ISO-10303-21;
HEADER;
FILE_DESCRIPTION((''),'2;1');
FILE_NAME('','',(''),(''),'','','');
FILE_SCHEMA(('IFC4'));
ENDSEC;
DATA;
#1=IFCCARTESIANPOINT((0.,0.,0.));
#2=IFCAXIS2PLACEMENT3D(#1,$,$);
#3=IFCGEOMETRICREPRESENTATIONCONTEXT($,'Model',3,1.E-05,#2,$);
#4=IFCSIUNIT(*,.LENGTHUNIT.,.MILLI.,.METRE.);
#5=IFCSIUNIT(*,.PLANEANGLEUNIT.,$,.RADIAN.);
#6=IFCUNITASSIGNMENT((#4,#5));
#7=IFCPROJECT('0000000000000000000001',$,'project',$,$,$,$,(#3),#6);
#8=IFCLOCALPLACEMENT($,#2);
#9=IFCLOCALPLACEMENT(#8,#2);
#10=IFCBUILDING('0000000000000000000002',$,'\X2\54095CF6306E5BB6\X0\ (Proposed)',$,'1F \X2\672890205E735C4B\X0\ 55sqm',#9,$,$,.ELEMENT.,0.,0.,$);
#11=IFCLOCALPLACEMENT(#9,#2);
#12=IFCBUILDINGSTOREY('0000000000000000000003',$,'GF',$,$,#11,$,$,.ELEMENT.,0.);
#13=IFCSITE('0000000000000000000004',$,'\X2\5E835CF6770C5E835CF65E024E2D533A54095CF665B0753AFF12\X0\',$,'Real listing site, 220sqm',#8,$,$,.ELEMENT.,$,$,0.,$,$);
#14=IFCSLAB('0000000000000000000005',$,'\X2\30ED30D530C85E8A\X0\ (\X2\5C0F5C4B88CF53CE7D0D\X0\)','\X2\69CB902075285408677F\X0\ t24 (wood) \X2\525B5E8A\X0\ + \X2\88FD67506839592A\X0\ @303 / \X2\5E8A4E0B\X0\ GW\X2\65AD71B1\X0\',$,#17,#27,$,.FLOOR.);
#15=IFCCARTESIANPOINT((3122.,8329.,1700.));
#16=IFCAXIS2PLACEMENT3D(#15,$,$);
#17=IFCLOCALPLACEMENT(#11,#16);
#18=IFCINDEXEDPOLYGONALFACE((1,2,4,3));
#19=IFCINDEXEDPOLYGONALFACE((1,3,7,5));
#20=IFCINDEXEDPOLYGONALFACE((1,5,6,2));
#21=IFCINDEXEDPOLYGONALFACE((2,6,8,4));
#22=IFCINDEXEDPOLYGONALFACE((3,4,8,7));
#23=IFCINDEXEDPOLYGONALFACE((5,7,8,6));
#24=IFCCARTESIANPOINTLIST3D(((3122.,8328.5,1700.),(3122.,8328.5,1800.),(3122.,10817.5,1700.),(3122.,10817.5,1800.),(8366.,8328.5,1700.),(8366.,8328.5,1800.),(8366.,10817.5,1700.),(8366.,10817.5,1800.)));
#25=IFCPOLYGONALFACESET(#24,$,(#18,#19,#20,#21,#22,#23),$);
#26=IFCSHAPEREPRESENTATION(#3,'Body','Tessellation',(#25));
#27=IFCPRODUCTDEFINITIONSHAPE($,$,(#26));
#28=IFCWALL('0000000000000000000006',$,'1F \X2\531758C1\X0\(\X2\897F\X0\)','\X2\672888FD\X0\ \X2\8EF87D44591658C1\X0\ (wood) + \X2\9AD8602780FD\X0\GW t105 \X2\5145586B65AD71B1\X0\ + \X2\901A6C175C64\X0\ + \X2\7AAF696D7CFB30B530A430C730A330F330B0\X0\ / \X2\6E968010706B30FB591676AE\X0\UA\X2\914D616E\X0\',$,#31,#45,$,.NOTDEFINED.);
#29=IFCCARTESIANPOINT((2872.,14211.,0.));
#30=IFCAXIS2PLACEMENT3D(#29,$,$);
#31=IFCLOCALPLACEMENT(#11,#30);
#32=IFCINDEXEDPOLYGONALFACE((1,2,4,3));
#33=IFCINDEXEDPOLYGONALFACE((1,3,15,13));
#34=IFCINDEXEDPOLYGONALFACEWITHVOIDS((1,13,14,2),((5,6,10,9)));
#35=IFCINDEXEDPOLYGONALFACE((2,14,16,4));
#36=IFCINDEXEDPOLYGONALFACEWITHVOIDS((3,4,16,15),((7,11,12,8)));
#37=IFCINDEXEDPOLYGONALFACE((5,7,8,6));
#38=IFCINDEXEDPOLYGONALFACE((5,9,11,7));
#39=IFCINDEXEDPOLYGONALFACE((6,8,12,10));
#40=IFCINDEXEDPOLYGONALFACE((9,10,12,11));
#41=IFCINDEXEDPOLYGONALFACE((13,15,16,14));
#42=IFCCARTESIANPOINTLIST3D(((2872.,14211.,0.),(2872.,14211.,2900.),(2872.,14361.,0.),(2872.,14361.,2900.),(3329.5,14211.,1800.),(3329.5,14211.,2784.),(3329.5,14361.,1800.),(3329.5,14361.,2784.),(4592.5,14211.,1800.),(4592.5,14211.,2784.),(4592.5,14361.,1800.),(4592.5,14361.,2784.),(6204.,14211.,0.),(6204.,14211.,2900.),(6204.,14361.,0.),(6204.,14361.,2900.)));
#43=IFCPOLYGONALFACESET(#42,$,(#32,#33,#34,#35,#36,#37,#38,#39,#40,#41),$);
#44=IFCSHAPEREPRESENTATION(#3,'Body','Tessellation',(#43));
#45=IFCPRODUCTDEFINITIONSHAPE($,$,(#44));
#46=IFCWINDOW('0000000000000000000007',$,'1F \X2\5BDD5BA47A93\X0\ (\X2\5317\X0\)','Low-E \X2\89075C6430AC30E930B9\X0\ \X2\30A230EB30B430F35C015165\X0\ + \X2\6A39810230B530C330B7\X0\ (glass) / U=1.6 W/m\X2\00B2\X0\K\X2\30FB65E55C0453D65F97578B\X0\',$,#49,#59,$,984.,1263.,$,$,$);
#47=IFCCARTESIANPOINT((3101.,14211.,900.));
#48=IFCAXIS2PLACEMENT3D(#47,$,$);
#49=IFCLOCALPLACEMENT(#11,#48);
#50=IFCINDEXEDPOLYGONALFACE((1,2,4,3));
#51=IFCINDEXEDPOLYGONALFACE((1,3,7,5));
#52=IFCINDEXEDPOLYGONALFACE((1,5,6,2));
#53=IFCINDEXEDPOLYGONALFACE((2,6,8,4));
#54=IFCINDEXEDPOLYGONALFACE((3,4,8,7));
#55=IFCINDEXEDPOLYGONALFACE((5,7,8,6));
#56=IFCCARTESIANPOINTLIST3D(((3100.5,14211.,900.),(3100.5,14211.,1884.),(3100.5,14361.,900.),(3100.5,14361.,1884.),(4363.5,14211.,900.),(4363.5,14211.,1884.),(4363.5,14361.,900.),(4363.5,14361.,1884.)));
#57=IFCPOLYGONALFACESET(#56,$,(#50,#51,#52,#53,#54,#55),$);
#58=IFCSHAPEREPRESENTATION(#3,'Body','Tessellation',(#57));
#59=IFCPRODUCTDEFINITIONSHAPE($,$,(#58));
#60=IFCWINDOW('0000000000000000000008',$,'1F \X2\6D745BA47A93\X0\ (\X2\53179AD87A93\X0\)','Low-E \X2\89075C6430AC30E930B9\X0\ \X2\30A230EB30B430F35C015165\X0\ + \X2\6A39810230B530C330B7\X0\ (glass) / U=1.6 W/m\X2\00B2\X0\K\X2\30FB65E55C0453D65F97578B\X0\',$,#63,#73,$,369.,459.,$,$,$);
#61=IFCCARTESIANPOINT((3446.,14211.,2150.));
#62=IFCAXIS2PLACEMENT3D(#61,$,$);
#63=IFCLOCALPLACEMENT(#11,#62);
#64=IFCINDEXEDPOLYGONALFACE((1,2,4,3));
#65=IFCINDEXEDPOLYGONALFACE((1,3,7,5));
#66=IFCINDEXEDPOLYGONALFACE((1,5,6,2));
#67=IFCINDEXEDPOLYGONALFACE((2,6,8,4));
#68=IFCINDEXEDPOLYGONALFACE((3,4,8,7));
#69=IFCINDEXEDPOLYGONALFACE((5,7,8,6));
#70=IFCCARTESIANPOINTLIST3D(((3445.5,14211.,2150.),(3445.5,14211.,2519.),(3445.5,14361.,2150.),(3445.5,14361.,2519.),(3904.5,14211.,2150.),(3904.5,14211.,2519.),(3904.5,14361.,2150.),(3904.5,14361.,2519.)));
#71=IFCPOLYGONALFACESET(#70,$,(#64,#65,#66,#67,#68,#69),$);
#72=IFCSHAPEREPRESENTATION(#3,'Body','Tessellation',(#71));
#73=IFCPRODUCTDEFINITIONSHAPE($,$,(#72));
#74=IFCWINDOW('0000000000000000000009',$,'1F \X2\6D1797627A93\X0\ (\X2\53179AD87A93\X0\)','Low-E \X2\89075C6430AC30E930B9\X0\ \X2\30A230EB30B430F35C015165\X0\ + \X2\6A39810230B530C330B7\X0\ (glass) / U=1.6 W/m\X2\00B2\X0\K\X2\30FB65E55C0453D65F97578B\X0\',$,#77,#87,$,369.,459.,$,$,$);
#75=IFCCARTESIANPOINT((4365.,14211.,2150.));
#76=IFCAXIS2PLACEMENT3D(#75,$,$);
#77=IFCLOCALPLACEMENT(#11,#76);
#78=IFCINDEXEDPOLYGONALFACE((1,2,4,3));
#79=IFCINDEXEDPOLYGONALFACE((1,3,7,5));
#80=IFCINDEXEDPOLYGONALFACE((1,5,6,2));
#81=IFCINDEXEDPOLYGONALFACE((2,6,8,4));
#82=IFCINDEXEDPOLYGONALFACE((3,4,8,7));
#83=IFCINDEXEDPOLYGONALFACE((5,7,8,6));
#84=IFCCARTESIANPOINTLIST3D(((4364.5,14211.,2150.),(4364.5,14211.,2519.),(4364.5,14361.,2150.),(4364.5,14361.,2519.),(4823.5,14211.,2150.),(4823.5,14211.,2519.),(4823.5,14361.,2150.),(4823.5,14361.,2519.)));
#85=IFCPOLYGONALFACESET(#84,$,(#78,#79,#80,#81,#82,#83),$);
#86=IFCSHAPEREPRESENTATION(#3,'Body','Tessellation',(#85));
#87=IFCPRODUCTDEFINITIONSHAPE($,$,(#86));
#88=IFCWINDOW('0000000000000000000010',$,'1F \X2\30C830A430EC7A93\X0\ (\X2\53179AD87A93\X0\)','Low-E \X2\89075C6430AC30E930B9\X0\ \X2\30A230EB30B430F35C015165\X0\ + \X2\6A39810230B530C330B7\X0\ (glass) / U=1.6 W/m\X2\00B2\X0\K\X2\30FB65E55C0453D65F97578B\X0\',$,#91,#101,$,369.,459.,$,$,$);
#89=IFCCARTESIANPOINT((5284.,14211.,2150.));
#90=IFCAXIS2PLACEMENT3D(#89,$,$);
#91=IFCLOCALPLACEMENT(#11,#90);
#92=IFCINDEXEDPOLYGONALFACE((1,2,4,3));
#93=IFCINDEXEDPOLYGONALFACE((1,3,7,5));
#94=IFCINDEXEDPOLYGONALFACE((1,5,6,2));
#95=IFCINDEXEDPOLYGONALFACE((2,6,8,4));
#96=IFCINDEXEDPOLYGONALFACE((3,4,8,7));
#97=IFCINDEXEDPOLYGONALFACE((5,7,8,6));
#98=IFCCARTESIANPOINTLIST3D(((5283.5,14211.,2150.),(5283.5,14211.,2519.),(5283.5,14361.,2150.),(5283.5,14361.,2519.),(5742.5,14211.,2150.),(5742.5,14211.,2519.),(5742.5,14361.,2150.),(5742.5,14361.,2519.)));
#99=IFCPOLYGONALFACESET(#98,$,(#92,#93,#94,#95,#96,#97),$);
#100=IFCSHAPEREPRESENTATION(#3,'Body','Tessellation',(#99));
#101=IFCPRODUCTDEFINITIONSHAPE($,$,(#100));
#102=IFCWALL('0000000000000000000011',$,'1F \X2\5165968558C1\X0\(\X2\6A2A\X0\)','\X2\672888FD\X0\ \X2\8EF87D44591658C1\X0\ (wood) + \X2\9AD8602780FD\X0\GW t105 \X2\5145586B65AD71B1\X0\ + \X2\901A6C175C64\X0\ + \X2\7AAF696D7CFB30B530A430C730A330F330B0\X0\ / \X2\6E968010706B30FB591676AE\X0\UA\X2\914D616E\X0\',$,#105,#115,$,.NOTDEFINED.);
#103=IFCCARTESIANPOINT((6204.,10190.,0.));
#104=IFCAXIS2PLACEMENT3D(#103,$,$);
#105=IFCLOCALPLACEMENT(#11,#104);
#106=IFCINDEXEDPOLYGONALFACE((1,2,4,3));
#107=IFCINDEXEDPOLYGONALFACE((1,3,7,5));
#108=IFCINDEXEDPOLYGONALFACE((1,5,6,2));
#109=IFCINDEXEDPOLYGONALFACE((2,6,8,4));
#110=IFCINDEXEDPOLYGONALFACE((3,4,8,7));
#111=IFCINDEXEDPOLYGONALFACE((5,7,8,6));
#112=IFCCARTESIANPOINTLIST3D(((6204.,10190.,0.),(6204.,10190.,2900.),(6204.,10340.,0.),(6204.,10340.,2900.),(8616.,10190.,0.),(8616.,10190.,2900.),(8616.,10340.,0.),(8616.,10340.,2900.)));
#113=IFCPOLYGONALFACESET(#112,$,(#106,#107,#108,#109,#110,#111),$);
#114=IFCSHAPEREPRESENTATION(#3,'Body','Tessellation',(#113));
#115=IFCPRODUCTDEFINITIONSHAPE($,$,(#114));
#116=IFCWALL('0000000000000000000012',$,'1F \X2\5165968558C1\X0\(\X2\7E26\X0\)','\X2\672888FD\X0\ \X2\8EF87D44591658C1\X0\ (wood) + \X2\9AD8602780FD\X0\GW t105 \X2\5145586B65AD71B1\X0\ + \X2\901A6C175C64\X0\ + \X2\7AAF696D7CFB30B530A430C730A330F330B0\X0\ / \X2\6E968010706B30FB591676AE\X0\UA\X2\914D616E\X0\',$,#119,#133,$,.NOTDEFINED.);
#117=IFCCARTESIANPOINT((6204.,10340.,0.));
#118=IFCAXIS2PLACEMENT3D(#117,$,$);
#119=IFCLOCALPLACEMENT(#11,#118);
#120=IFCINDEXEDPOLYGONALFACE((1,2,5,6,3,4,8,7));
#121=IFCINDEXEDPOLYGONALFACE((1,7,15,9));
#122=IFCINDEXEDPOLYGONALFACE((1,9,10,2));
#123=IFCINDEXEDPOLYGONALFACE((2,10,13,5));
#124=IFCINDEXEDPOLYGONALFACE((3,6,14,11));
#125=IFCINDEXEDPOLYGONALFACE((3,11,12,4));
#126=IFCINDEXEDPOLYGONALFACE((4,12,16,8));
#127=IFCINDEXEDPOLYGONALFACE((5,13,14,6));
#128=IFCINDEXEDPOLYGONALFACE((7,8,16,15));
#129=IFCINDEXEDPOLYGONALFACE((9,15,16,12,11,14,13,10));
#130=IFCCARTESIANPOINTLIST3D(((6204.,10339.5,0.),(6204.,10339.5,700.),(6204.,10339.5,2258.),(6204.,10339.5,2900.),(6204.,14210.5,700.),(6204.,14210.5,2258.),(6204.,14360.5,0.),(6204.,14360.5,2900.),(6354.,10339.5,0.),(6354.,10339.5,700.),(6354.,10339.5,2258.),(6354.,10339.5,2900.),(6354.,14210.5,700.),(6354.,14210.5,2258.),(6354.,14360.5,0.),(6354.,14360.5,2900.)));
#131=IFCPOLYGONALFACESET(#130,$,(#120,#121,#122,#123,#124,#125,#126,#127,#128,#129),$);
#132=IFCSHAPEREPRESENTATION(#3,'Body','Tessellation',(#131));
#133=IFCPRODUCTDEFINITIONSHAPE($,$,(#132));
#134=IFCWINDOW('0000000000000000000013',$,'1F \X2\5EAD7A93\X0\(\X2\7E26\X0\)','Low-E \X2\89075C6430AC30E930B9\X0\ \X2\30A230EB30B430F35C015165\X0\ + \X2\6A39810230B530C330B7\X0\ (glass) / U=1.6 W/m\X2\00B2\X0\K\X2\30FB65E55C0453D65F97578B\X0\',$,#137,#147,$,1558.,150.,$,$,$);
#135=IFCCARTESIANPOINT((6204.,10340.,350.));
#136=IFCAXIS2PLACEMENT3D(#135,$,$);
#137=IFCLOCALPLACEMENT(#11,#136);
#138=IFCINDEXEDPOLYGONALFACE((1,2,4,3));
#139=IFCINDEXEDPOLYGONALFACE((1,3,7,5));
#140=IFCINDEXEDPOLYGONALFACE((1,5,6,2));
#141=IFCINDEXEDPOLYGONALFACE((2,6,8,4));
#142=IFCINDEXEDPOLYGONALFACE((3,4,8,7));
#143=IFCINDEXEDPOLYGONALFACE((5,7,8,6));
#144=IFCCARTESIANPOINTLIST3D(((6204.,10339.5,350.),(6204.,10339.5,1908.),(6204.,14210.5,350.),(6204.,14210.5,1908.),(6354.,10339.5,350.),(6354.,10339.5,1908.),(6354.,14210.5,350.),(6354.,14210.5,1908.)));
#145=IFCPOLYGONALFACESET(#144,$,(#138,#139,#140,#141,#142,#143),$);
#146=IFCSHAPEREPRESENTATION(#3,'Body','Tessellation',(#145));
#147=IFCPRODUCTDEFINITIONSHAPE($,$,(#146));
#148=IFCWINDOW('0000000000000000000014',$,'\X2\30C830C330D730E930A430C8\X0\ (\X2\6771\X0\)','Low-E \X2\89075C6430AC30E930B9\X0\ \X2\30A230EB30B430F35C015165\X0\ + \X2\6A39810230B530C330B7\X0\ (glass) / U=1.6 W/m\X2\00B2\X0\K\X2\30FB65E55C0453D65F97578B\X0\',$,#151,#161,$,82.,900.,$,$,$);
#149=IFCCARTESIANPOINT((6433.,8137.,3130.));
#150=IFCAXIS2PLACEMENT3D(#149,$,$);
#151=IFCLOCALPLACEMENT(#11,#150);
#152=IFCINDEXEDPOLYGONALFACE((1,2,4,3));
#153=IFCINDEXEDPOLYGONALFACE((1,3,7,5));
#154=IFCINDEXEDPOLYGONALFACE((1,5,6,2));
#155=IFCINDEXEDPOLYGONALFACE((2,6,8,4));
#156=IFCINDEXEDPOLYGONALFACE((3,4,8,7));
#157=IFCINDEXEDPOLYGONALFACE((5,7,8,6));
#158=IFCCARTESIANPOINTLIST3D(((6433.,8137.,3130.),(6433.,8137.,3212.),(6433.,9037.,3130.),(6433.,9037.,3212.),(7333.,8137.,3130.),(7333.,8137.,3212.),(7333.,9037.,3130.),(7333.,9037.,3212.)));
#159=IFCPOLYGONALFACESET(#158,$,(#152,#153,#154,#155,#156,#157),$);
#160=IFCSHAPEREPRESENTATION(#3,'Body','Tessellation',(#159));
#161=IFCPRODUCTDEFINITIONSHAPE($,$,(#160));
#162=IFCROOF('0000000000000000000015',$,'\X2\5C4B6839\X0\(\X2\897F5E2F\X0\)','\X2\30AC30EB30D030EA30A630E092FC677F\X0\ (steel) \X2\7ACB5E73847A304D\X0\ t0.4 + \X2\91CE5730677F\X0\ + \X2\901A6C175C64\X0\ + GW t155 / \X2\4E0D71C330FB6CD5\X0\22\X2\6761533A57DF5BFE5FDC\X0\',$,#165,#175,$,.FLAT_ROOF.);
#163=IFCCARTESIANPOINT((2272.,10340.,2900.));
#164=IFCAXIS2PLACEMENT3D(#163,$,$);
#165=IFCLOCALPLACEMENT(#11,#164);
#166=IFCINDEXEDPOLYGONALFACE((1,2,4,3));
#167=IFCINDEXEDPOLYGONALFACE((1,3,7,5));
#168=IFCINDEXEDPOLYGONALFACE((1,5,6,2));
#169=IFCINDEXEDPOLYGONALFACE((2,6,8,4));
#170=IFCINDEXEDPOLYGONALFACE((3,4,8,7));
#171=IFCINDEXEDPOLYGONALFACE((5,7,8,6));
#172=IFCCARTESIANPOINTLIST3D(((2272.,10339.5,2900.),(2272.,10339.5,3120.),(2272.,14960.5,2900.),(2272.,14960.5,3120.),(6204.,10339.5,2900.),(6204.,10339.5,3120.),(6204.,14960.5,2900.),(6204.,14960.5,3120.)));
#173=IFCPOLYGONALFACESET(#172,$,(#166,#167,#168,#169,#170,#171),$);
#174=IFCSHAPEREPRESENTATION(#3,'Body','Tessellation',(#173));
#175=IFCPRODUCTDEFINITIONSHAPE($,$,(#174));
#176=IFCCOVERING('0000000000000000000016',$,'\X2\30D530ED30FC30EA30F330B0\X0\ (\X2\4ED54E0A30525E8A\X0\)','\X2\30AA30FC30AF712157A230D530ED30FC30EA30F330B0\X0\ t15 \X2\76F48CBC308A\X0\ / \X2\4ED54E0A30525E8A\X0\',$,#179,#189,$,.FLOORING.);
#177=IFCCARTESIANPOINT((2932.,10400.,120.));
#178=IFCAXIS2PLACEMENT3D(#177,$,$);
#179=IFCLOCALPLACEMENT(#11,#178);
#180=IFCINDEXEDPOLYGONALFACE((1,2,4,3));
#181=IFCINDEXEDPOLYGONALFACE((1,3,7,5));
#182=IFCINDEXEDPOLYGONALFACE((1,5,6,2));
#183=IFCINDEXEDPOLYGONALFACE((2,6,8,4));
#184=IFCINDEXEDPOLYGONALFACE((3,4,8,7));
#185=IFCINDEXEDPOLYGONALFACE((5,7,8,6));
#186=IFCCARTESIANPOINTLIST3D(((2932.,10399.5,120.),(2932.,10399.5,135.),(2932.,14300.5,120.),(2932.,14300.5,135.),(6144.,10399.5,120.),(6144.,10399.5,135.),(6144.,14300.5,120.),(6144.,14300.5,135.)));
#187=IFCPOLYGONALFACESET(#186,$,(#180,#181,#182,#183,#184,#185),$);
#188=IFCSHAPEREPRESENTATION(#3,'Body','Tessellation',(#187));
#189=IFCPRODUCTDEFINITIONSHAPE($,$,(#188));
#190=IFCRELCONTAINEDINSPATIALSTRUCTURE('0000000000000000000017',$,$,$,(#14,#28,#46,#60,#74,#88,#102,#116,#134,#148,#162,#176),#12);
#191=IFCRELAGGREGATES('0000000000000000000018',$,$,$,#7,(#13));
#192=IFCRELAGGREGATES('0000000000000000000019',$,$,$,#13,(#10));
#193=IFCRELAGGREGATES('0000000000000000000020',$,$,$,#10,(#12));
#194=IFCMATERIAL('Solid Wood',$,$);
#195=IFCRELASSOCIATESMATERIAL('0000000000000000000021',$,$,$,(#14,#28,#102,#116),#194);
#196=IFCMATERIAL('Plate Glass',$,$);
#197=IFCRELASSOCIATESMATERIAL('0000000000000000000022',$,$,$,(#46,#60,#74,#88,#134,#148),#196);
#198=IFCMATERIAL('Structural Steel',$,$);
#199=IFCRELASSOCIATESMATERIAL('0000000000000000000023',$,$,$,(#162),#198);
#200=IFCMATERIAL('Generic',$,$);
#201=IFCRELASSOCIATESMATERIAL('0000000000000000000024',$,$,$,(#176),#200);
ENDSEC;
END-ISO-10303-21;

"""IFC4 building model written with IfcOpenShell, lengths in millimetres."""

from ifc_helpers import new_model, si_unit, frame, frame_2d, origin, place, context, project, spatial, rectangle, extrude, material, element, fill, save


model = new_model("IFC4")

# Units and contexts
model_context = context("Model", 3, precision=1e-05, world=origin())
ifc_project = project(units=[si_unit("LENGTHUNIT", "METRE", prefix="MILLI"), si_unit("PLANEANGLEUNIT", "RADIAN")], contexts=[model_context])

# Site, building, storey
site_placement = place(None, origin())
site = spatial("IfcSite", under=ifc_project, at=site_placement, Name="広島県広島市中区吉島新町２", ObjectType="Real listing site, 220sqm", CompositionType="ELEMENT", RefElevation=0.0)
building_placement = place(site_placement, origin())
building = spatial("IfcBuilding", under=site, at=building_placement, Name="吉島の家 (Proposed)", ObjectType="1F 木造平屋 55sqm", CompositionType="ELEMENT", ElevationOfRefHeight=0.0, ElevationOfTerrain=0.0)
storey_placement = place(building_placement, origin())
storey = spatial("IfcBuildingStorey", under=building, at=storey_placement, Name="GF", CompositionType="ELEMENT", Elevation=0.0)

# Slab
ifc_material_1 = material(Name="Solid Wood")
slab_1_placement = place(storey_placement, frame((3122.0, 8329.0, 1700.0)))
element("IfcSlab", 1, at=slab_1_placement, inside=storey, material=ifc_material_1, Name="ロフト床 (小屋裏収納)", Description="構造用合板 t24 (wood) 剛床 + 製材根太 @303 / 床下 GW断熱", PredefinedType="FLOOR", context=model_context, shape_type="SweptSolid", body=[
    extrude(rectangle(XDim=5244.0, YDim=2489.0, at=frame_2d((2622.0, 1244.0))), frame((3122.0, 8329.0, 1700.0)), (0.0, 0.0, 1.0), 100.0),
])

# Wall, openings, windows
wall_1_placement = place(storey_placement, frame((2872.0, 14211.0, 0.0)))
wall_1 = element("IfcWall", 2, at=wall_1_placement, inside=storey, material=ifc_material_1, Name="1F 北壁(西)", Description="木製 軸組外壁 (wood) + 高性能GW t105 充填断熱 + 通気層 + 窯業系サイディング / 準耐火・外皮UA配慮", PredefinedType="NOTDEFINED", context=model_context, shape_type="SweptSolid", body=[
    extrude(rectangle(XDim=3332.0, YDim=150.0, at=frame_2d((1666.0, 75.0))), frame((2872.0, 14211.0, 0.0)), (0.0, 0.0, 1.0), 2900.0),
])
opening_1_placement = place(storey_placement, frame((3101.0, 14211.0, 900.0)))
opening_1 = element("IfcOpeningElement", 3, at=opening_1_placement, cuts=wall_1, PredefinedType="NOTDEFINED", context=model_context, shape_type="SweptSolid", body=[
    extrude(rectangle(XDim=1263.0, YDim=150.0, at=frame_2d((631.0, 75.0))), frame((3101.0, 14211.0, 900.0)), (0.0, 0.0, 1.0), 984.0),
])
opening_2_placement = place(storey_placement, frame((3446.0, 14211.0, 2150.0)))
opening_2 = element("IfcOpeningElement", 4, at=opening_2_placement, cuts=wall_1, PredefinedType="NOTDEFINED", context=model_context, shape_type="SweptSolid", body=[
    extrude(rectangle(XDim=459.0, YDim=150.0, at=frame_2d((229.0, 75.0))), frame((3446.0, 14211.0, 2150.0)), (0.0, 0.0, 1.0), 369.0),
])
opening_3_placement = place(storey_placement, frame((4365.0, 14211.0, 2150.0)))
opening_3 = element("IfcOpeningElement", 5, at=opening_3_placement, cuts=wall_1, PredefinedType="NOTDEFINED", context=model_context, shape_type="SweptSolid", body=[
    extrude(rectangle(XDim=459.0, YDim=150.0, at=frame_2d((229.0, 75.0))), frame((4365.0, 14211.0, 2150.0)), (0.0, 0.0, 1.0), 369.0),
])
opening_4_placement = place(storey_placement, frame((5284.0, 14211.0, 2150.0)))
opening_4 = element("IfcOpeningElement", 6, at=opening_4_placement, cuts=wall_1, PredefinedType="NOTDEFINED", context=model_context, shape_type="SweptSolid", body=[
    extrude(rectangle(XDim=459.0, YDim=150.0, at=frame_2d((229.0, 75.0))), frame((5284.0, 14211.0, 2150.0)), (0.0, 0.0, 1.0), 369.0),
])
ifc_material_2 = material(Name="Plate Glass")
window_1_placement = place(storey_placement, frame((3101.0, 14211.0, 900.0)))
window_1 = element("IfcWindow", 7, at=window_1_placement, inside=storey, material=ifc_material_2, Name="1F 寝室窓 (北)", Description="Low-E 複層ガラス アルゴン封入 + 樹脂サッシ (glass) / U=1.6 W/m²K・日射取得型", OverallHeight=984.0, OverallWidth=1263.0, context=model_context, shape_type="SweptSolid", body=[
    extrude(rectangle(XDim=1263.0, YDim=150.0, at=frame_2d((631.0, 75.0))), frame((3101.0, 14211.0, 900.0)), (0.0, 0.0, 1.0), 984.0),
])
fill(opening_1, window_1)
window_2_placement = place(storey_placement, frame((3446.0, 14211.0, 2150.0)))
window_2 = element("IfcWindow", 8, at=window_2_placement, inside=storey, material=ifc_material_2, Name="1F 浴室窓 (北高窓)", Description="Low-E 複層ガラス アルゴン封入 + 樹脂サッシ (glass) / U=1.6 W/m²K・日射取得型", OverallHeight=369.0, OverallWidth=459.0, context=model_context, shape_type="SweptSolid", body=[
    extrude(rectangle(XDim=459.0, YDim=150.0, at=frame_2d((229.0, 75.0))), frame((3446.0, 14211.0, 2150.0)), (0.0, 0.0, 1.0), 369.0),
])
fill(opening_2, window_2)
window_3_placement = place(storey_placement, frame((4365.0, 14211.0, 2150.0)))
window_3 = element("IfcWindow", 9, at=window_3_placement, inside=storey, material=ifc_material_2, Name="1F 洗面窓 (北高窓)", Description="Low-E 複層ガラス アルゴン封入 + 樹脂サッシ (glass) / U=1.6 W/m²K・日射取得型", OverallHeight=369.0, OverallWidth=459.0, context=model_context, shape_type="SweptSolid", body=[
    extrude(rectangle(XDim=459.0, YDim=150.0, at=frame_2d((229.0, 75.0))), frame((4365.0, 14211.0, 2150.0)), (0.0, 0.0, 1.0), 369.0),
])
fill(opening_3, window_3)
window_4_placement = place(storey_placement, frame((5284.0, 14211.0, 2150.0)))
window_4 = element("IfcWindow", 10, at=window_4_placement, inside=storey, material=ifc_material_2, Name="1F トイレ窓 (北高窓)", Description="Low-E 複層ガラス アルゴン封入 + 樹脂サッシ (glass) / U=1.6 W/m²K・日射取得型", OverallHeight=369.0, OverallWidth=459.0, context=model_context, shape_type="SweptSolid", body=[
    extrude(rectangle(XDim=459.0, YDim=150.0, at=frame_2d((229.0, 75.0))), frame((5284.0, 14211.0, 2150.0)), (0.0, 0.0, 1.0), 369.0),
])
fill(opening_4, window_4)

# Wall
wall_2_placement = place(storey_placement, frame((6204.0, 10190.0, 0.0)))
element("IfcWall", 11, at=wall_2_placement, inside=storey, material=ifc_material_1, Name="1F 入隅壁(横)", Description="木製 軸組外壁 (wood) + 高性能GW t105 充填断熱 + 通気層 + 窯業系サイディング / 準耐火・外皮UA配慮", PredefinedType="NOTDEFINED", context=model_context, shape_type="SweptSolid", body=[
    extrude(rectangle(XDim=2412.0, YDim=150.0, at=frame_2d((1206.0, 75.0))), frame((6204.0, 10190.0, 0.0)), (0.0, 0.0, 1.0), 2900.0),
])

# Wall, opening, window
wall_3_placement = place(storey_placement, frame((6204.0, 10340.0, 0.0)))
wall_3 = element("IfcWall", 12, at=wall_3_placement, inside=storey, material=ifc_material_1, Name="1F 入隅壁(縦)", Description="木製 軸組外壁 (wood) + 高性能GW t105 充填断熱 + 通気層 + 窯業系サイディング / 準耐火・外皮UA配慮", PredefinedType="NOTDEFINED", context=model_context, shape_type="SweptSolid", body=[
    extrude(rectangle(XDim=150.0, YDim=4021.0, at=frame_2d((75.0, 2010.0))), frame((6204.0, 10340.0, 0.0)), (0.0, 0.0, 1.0), 2900.0),
])
opening_5_placement = place(storey_placement, frame((6204.0, 10340.0, 350.0)))
opening_5 = element("IfcOpeningElement", 13, at=opening_5_placement, cuts=wall_3, PredefinedType="NOTDEFINED", context=model_context, shape_type="SweptSolid", body=[
    extrude(rectangle(XDim=150.0, YDim=3871.0, at=frame_2d((75.0, 1935.0))), frame((6204.0, 10340.0, 350.0)), (0.0, 0.0, 1.0), 1558.0),
])
window_5_placement = place(storey_placement, frame((6204.0, 10340.0, 350.0)))
window_5 = element("IfcWindow", 14, at=window_5_placement, inside=storey, material=ifc_material_2, Name="1F 庭窓(縦)", Description="Low-E 複層ガラス アルゴン封入 + 樹脂サッシ (glass) / U=1.6 W/m²K・日射取得型", OverallHeight=1558.0, OverallWidth=150.0, context=model_context, shape_type="SweptSolid", body=[
    extrude(rectangle(XDim=150.0, YDim=3871.0, at=frame_2d((75.0, 1935.0))), frame((6204.0, 10340.0, 350.0)), (0.0, 0.0, 1.0), 1558.0),
])
fill(opening_5, window_5)

# Window
window_6_placement = place(storey_placement, frame((6433.0, 8137.0, 3130.0)))
element("IfcWindow", 15, at=window_6_placement, inside=storey, material=ifc_material_2, Name="トップライト (東)", Description="Low-E 複層ガラス アルゴン封入 + 樹脂サッシ (glass) / U=1.6 W/m²K・日射取得型", OverallHeight=82.0, OverallWidth=900.0, context=model_context, shape_type="SweptSolid", body=[
    extrude(rectangle(XDim=900.0, YDim=900.0, at=frame_2d((450.0, 450.0))), frame((6433.0, 8137.0, 3130.0)), (0.0, 0.0, 1.0), 82.0),
])

# Roof
ifc_material_3 = material(Name="Structural Steel")
roof_placement = place(storey_placement, frame((2272.0, 10340.0, 2900.0)))
element("IfcRoof", 16, at=roof_placement, inside=storey, material=ifc_material_3, Name="屋根(西帯)", Description="ガルバリウム鋼板 (steel) 立平葺き t0.4 + 野地板 + 通気層 + GW t155 / 不燃・法22条区域対応", PredefinedType="FLAT_ROOF", context=model_context, shape_type="SweptSolid", body=[
    extrude(rectangle(XDim=3932.0, YDim=4621.0, at=frame_2d((1966.0, 2310.0))), frame((2272.0, 10340.0, 2900.0)), (0.0, 0.0, 1.0), 220.0),
])

# Covering
ifc_material_4 = material(Name="Generic")
covering_placement = place(storey_placement, frame((2932.0, 10400.0, 120.0)))
element("IfcCovering", 17, at=covering_placement, inside=storey, material=ifc_material_4, Name="フローリング (仕上げ床)", Description="オーク無垢フローリング t15 直貼り / 仕上げ床", PredefinedType="FLOORING", context=model_context, shape_type="SweptSolid", body=[
    extrude(rectangle(XDim=3212.0, YDim=3901.0, at=frame_2d((1606.0, 1950.0))), frame((2932.0, 10400.0, 120.0)), (0.0, 0.0, 1.0), 15.0),
])

save(model, "model.ifc")
